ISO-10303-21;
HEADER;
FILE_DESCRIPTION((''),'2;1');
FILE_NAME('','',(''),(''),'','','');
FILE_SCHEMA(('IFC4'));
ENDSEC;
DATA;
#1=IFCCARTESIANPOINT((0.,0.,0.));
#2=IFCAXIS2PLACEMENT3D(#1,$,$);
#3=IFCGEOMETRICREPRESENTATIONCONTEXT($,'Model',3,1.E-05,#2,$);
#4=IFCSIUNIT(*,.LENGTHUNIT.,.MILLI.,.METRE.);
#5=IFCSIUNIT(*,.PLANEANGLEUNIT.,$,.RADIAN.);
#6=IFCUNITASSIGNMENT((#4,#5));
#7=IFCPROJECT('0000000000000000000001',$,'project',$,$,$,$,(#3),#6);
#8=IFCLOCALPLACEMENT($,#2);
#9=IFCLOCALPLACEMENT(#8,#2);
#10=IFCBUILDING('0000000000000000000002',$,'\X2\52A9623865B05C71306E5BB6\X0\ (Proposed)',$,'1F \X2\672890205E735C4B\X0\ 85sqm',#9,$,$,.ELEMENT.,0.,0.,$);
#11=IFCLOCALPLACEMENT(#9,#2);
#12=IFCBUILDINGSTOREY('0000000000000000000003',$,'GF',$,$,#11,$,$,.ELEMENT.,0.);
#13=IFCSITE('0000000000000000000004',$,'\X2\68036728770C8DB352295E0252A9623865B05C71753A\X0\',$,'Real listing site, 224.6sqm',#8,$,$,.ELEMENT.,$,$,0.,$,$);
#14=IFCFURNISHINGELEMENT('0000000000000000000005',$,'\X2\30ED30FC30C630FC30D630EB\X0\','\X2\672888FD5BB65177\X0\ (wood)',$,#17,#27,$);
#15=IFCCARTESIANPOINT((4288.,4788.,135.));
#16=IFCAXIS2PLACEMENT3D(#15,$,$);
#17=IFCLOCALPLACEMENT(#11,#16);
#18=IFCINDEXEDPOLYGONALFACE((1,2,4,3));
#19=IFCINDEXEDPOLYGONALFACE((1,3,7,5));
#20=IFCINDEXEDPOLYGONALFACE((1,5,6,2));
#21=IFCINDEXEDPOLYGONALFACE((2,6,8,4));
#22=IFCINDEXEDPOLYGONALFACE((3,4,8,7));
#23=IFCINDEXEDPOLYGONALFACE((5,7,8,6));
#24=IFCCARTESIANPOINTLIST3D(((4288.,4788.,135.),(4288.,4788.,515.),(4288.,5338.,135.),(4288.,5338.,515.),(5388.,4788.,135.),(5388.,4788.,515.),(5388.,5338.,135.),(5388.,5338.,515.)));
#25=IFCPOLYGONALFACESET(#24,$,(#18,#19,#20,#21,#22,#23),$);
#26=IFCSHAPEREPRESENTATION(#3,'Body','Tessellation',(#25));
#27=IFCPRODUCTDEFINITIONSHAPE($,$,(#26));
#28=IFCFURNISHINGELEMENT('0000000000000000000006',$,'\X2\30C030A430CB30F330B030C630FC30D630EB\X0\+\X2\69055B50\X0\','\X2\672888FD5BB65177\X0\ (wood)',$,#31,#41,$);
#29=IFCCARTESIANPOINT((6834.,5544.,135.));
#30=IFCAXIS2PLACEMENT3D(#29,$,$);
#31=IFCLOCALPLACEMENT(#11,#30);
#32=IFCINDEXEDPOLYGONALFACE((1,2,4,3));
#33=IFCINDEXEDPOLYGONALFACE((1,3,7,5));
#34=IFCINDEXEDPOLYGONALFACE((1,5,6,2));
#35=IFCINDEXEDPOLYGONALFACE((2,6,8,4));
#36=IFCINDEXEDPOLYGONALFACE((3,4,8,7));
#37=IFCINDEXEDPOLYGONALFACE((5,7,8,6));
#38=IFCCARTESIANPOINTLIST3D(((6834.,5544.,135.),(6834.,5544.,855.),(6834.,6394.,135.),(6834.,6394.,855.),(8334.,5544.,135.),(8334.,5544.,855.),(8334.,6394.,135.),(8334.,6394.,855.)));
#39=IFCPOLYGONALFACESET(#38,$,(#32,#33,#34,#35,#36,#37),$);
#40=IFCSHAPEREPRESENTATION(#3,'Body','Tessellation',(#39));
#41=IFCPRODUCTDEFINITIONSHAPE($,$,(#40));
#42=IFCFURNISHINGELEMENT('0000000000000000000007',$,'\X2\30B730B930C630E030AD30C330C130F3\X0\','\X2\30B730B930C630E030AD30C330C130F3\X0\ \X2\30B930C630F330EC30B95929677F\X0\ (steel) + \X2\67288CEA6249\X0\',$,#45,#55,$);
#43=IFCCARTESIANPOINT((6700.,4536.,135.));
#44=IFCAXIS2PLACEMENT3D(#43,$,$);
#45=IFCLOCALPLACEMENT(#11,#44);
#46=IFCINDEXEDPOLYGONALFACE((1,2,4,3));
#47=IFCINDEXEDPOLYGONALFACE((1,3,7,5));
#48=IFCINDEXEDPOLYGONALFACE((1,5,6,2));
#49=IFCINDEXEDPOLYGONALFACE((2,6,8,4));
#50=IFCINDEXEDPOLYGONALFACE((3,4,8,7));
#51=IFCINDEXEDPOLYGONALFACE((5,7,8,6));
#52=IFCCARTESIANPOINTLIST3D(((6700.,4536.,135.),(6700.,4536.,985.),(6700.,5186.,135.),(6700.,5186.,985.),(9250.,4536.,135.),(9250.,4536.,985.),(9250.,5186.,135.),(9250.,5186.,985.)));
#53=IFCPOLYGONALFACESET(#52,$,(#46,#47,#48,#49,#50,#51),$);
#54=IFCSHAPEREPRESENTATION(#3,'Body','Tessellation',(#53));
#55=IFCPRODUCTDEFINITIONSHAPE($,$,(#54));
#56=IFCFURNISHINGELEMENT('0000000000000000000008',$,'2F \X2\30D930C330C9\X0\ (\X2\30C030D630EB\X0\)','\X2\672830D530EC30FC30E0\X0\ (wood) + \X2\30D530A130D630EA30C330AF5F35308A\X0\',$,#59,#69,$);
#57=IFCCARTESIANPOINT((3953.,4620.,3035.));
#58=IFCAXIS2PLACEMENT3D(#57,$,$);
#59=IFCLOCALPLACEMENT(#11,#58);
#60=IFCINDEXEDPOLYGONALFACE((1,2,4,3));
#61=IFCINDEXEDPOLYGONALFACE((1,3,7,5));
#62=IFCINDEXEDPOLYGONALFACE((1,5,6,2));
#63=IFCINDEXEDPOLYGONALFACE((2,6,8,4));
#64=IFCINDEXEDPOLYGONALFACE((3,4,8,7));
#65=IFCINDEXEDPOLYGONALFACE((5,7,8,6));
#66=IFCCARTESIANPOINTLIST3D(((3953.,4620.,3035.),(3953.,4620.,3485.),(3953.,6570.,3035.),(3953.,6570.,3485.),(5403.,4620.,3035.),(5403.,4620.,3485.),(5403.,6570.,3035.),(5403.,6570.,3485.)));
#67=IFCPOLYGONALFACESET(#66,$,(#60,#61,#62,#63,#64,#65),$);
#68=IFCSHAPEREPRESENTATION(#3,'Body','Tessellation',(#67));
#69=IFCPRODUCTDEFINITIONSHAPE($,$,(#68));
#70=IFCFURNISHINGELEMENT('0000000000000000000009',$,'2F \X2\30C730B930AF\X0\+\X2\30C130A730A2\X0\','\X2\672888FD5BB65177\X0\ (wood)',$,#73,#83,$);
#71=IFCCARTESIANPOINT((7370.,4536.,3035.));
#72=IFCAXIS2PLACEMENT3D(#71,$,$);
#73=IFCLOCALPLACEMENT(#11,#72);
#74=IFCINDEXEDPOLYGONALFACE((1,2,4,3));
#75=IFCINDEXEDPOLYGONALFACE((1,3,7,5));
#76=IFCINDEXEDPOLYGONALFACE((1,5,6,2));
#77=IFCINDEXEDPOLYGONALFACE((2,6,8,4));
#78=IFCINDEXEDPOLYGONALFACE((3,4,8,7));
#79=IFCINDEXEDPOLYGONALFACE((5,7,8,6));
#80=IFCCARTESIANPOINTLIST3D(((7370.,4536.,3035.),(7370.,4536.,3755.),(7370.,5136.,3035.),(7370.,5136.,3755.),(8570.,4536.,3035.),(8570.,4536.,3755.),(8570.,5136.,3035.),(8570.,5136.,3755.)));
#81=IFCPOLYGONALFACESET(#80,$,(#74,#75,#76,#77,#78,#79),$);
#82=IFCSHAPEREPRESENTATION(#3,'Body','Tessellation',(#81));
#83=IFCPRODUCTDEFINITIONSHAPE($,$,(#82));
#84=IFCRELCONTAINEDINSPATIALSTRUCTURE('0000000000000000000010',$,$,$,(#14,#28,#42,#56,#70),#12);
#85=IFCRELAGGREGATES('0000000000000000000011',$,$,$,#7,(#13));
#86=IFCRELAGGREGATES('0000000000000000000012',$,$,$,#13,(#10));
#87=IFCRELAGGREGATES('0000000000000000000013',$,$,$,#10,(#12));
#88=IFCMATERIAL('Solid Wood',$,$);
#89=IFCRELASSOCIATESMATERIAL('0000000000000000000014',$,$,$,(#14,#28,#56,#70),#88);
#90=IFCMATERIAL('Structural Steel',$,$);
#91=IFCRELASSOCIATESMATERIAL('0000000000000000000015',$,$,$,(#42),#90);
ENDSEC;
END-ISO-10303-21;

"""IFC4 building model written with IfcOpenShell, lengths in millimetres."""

from ifc_helpers import new_model, si_unit, frame, frame_2d, origin, place, context, project, spatial, rectangle, extrude, material, element, save


model = new_model("IFC4")

# Units and contexts
model_context = context("Model", 3, precision=1e-05, world=origin())
ifc_project = project(units=[si_unit("LENGTHUNIT", "METRE", prefix="MILLI"), si_unit("PLANEANGLEUNIT", "RADIAN")], contexts=[model_context])

# Site, building, storey
site_placement = place(None, origin())
site = spatial("IfcSite", under=ifc_project, at=site_placement, Name="栃木県足利市助戸新山町", ObjectType="Real listing site, 224.6sqm", CompositionType="ELEMENT", RefElevation=0.0)
building_placement = place(site_placement, origin())
building = spatial("IfcBuilding", under=site, at=building_placement, Name="助戸新山の家 (Proposed)", ObjectType="1F 木造平屋 85sqm", CompositionType="ELEMENT", ElevationOfRefHeight=0.0, ElevationOfTerrain=0.0)
storey_placement = place(building_placement, origin())
storey = spatial("IfcBuildingStorey", under=building, at=storey_placement, Name="GF", CompositionType="ELEMENT", Elevation=0.0)

# Shared definitions
ifc_material_1 = material(Name="Solid Wood")

# Shared definitions
ifc_material_2 = material(Name="Structural Steel")

# Furnishing elements
furnishing_1_placement = place(storey_placement, frame((4288.0, 4788.0, 135.0)))
element("IfcFurnishingElement", 1, at=furnishing_1_placement, inside=storey, material=ifc_material_1, Name="ローテーブル", Description="木製家具 (wood)", context=model_context, shape_type="SweptSolid", body=[
    extrude(rectangle(XDim=1100.0, YDim=550.0, at=frame_2d((550.0, 275.0))), frame((4288.0, 4788.0, 135.0)), (0.0, 0.0, 1.0), 380.0),
])
furnishing_2_placement = place(storey_placement, frame((6834.0, 5544.0, 135.0)))
element("IfcFurnishingElement", 2, at=furnishing_2_placement, inside=storey, material=ifc_material_1, Name="ダイニングテーブル+椅子", Description="木製家具 (wood)", context=model_context, shape_type="SweptSolid", body=[
    extrude(rectangle(XDim=1500.0, YDim=850.0, at=frame_2d((750.0, 425.0))), frame((6834.0, 5544.0, 135.0)), (0.0, 0.0, 1.0), 720.0),
])
furnishing_3_placement = place(storey_placement, frame((6700.0, 4536.0, 135.0)))
element("IfcFurnishingElement", 3, at=furnishing_3_placement, inside=storey, material=ifc_material_2, Name="システムキッチン", Description="システムキッチン ステンレス天板 (steel) + 木質扉", context=model_context, shape_type="SweptSolid", body=[
    extrude(rectangle(XDim=2550.0, YDim=650.0, at=frame_2d((1275.0, 325.0))), frame((6700.0, 4536.0, 135.0)), (0.0, 0.0, 1.0), 850.0),
])
furnishing_4_placement = place(storey_placement, frame((3953.0, 4620.0, 3035.0)))
element("IfcFurnishingElement", 4, at=furnishing_4_placement, inside=storey, material=ifc_material_1, Name="2F ベッド (ダブル)", Description="木フレーム (wood) + ファブリック張り", context=model_context, shape_type="SweptSolid", body=[
    extrude(rectangle(XDim=1450.0, YDim=1950.0, at=frame_2d((725.0, 975.0))), frame((3953.0, 4620.0, 3035.0)), (0.0, 0.0, 1.0), 450.0),
])
furnishing_5_placement = place(storey_placement, frame((7370.0, 4536.0, 3035.0)))
element("IfcFurnishingElement", 5, at=furnishing_5_placement, inside=storey, material=ifc_material_1, Name="2F デスク+チェア", Description="木製家具 (wood)", context=model_context, shape_type="SweptSolid", body=[
    extrude(rectangle(XDim=1200.0, YDim=600.0, at=frame_2d((600.0, 300.0))), frame((7370.0, 4536.0, 3035.0)), (0.0, 0.0, 1.0), 720.0),
])

save(model, "model.ifc")
